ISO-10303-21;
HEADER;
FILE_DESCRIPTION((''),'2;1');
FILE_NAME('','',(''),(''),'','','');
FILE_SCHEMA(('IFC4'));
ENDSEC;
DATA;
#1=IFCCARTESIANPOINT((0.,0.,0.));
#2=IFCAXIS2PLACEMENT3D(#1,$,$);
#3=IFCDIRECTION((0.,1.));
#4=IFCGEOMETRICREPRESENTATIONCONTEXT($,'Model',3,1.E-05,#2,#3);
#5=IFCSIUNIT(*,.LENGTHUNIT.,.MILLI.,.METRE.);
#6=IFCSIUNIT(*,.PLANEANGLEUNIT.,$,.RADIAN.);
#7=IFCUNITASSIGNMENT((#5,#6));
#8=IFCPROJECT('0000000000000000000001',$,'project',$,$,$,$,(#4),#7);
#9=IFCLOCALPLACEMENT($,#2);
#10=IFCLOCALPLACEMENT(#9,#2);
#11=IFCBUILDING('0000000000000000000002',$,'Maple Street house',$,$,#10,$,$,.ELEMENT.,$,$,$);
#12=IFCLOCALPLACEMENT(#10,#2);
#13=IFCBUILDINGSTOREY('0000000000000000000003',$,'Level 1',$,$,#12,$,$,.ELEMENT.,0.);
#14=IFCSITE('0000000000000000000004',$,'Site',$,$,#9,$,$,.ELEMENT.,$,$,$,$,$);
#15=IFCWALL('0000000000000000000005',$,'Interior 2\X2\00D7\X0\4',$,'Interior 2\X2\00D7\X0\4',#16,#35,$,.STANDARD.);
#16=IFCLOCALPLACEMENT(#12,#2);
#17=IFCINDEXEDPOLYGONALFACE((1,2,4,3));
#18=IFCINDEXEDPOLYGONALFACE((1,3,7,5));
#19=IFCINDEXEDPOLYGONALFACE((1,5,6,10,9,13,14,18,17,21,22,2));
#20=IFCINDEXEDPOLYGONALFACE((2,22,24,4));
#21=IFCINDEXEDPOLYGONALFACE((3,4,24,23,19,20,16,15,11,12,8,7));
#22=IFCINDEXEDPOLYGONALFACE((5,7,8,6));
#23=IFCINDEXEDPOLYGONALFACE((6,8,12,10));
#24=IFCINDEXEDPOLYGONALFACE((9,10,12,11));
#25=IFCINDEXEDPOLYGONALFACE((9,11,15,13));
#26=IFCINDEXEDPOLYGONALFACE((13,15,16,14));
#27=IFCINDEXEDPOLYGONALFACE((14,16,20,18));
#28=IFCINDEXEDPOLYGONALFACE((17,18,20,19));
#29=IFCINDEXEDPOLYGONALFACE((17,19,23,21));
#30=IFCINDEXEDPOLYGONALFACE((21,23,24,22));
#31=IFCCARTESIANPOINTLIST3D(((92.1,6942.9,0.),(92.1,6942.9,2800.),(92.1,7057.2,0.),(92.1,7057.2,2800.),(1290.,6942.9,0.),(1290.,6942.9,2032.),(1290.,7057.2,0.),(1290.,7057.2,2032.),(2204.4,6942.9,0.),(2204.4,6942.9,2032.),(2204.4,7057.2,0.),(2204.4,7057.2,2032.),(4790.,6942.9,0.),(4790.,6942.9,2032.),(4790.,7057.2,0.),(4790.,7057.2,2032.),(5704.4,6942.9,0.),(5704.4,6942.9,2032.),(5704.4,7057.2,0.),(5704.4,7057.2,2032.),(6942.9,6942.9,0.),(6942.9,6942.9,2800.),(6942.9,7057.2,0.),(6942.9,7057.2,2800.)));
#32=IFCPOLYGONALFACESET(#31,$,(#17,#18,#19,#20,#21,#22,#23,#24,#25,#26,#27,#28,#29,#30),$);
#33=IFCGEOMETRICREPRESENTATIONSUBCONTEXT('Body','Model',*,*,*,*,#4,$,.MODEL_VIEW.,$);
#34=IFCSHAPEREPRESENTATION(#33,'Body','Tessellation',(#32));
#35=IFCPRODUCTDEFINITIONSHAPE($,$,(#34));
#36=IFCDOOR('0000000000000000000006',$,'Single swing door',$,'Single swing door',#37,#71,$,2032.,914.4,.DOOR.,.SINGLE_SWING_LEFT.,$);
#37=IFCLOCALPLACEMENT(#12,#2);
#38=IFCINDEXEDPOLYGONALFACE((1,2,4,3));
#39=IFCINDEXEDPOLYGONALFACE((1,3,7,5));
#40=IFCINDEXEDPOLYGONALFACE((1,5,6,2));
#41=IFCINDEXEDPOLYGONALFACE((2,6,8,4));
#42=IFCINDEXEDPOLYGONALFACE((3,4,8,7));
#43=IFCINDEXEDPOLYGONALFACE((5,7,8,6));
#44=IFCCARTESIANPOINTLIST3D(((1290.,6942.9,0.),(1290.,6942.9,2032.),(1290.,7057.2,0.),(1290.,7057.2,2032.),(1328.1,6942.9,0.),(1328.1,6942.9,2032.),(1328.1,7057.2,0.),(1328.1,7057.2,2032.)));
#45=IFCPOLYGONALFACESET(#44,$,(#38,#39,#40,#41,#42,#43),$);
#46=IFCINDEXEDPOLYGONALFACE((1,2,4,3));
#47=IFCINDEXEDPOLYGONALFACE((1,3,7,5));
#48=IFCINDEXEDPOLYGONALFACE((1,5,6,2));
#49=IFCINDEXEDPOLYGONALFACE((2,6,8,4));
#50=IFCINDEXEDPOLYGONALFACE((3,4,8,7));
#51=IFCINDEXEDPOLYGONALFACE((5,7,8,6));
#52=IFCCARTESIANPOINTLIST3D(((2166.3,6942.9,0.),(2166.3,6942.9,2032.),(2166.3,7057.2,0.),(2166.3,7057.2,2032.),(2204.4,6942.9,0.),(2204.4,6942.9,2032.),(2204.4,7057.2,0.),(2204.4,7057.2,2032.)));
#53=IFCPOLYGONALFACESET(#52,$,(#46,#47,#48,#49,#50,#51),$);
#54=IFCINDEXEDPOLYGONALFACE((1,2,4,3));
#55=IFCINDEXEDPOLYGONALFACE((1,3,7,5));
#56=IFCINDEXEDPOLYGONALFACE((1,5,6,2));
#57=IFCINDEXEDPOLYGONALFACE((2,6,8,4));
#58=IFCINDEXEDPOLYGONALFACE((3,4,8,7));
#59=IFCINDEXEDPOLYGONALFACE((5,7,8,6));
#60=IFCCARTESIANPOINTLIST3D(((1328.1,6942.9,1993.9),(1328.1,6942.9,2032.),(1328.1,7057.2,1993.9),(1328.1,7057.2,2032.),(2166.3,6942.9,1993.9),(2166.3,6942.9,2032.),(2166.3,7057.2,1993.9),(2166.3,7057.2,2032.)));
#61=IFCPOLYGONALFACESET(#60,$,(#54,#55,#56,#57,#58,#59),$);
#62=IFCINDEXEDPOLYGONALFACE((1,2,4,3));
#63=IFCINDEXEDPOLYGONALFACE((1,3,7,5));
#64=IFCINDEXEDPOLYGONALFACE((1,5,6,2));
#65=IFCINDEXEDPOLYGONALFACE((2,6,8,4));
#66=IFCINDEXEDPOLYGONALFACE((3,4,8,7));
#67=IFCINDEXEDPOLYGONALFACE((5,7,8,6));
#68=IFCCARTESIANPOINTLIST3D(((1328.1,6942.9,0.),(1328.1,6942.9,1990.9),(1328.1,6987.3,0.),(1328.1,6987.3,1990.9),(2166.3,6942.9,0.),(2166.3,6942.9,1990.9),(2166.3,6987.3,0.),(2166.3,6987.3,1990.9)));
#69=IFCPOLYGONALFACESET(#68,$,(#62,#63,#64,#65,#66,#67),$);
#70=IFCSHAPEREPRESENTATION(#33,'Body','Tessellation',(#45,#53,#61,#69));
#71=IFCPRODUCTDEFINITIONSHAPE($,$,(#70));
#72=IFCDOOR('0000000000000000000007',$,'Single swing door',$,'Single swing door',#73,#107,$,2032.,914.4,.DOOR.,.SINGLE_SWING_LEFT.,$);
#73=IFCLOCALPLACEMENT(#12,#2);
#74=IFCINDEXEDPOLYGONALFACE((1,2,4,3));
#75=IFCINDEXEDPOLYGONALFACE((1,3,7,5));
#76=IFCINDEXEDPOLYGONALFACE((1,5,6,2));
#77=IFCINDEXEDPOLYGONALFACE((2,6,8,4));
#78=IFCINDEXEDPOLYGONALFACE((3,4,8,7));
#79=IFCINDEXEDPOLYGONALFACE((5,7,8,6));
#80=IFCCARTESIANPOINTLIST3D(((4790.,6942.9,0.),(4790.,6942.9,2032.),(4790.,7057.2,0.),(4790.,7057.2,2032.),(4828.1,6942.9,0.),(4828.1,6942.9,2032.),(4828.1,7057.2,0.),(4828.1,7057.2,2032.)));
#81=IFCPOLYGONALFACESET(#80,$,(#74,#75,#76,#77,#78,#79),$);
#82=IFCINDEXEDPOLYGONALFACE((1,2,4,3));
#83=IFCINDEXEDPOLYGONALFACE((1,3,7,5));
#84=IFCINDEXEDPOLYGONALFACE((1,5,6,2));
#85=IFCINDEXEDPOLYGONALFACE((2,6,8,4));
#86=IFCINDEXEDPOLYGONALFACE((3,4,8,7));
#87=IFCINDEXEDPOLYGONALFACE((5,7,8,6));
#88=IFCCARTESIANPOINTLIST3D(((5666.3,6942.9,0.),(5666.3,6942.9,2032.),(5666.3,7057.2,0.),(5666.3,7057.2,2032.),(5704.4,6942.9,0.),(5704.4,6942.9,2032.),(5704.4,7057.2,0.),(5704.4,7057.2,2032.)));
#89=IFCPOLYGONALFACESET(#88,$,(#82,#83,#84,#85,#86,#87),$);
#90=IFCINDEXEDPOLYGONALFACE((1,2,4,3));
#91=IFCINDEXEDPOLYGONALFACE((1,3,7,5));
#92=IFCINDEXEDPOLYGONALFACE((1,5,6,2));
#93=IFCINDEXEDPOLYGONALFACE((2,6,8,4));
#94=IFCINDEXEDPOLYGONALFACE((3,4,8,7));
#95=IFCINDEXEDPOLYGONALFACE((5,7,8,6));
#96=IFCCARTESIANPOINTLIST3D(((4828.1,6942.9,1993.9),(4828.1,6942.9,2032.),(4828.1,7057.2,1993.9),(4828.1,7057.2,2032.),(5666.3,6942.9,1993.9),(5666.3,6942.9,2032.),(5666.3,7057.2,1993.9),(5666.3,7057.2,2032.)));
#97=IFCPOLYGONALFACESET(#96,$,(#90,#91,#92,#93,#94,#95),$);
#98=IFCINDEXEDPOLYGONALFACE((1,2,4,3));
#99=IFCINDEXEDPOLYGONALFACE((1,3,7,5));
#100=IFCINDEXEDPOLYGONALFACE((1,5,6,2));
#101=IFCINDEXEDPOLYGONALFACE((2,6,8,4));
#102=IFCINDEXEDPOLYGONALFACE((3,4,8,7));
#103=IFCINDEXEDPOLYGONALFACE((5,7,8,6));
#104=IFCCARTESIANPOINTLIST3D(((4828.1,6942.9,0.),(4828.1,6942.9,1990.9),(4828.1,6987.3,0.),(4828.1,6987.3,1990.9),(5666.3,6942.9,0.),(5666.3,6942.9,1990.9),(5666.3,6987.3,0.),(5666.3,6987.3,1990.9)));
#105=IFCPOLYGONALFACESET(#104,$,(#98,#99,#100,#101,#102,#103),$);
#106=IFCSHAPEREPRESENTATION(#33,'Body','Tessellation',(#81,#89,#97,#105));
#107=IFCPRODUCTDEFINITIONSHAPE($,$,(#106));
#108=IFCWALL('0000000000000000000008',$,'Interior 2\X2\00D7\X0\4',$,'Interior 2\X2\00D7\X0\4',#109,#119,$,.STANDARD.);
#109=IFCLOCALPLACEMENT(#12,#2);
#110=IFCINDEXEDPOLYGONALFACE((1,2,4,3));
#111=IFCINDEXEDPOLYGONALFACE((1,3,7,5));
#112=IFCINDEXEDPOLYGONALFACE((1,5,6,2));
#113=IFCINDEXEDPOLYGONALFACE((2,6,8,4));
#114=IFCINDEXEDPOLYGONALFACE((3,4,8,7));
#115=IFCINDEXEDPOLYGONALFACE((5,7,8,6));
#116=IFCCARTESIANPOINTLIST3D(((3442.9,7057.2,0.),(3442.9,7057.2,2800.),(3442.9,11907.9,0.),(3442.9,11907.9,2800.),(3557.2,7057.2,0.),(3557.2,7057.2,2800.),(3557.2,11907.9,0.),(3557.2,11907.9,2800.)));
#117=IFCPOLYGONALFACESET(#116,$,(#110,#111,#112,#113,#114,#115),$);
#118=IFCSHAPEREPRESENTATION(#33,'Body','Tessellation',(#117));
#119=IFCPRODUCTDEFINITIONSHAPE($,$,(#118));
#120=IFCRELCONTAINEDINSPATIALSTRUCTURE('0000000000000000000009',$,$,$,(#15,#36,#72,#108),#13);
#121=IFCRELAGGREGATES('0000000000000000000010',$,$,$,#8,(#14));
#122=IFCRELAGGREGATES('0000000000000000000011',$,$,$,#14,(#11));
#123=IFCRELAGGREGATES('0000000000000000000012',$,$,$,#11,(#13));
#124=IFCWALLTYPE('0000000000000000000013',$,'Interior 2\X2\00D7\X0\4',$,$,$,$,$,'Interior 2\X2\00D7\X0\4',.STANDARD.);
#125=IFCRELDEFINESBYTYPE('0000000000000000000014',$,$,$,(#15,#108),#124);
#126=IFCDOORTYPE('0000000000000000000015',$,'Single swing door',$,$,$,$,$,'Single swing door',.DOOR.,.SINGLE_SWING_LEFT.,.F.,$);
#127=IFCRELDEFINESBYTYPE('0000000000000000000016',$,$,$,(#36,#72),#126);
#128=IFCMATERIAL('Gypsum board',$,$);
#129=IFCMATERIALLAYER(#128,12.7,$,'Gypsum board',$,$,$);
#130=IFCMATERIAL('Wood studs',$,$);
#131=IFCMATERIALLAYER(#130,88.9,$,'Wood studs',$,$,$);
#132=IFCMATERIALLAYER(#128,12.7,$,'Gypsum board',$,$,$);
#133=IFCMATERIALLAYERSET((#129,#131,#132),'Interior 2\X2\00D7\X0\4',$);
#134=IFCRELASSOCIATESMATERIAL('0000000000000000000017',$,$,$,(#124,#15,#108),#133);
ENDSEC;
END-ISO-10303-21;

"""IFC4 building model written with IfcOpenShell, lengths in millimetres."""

from ifc_helpers import new_model, si_unit, direction, frame, origin, origin_with_axes, place, context, subcontext, project, spatial, polyline, outline, extrude, material, layer, layer_set, layer_usage, type_object, element, fill, save


model = new_model("IFC4")

# Units and contexts
model_context = context("Model", 3, precision=1e-05, world=origin(), true_north=direction((0.0, 1.0)))
body_context = subcontext(model_context, "Body", "Model", "MODEL_VIEW")
ifc_project = project(units=[si_unit("LENGTHUNIT", "METRE", prefix="MILLI"), si_unit("PLANEANGLEUNIT", "RADIAN")], contexts=[model_context])

# Site, building, storey
site_placement = place(None, origin())
site = spatial("IfcSite", under=ifc_project, at=site_placement, Name="Site", CompositionType="ELEMENT")
building_placement = place(site_placement, origin())
building = spatial("IfcBuilding", under=site, at=building_placement, Name="Maple Street house", CompositionType="ELEMENT")
storey_placement = place(building_placement, origin())
storey = spatial("IfcBuildingStorey", under=building, at=storey_placement, Name="Level 1", CompositionType="ELEMENT", Elevation=0.0)

# Shared definitions
ifc_material_1 = material(Name="Wood studs")
ifc_material_2 = material(Name="Gypsum board")

# Wall, openings, doors
ifc_layer_1 = layer(ifc_material_2, 12.7, Name="Gypsum board")
ifc_layer_2 = layer(ifc_material_1, 88.9, Name="Wood studs")
ifc_layer_3 = layer(ifc_material_2, 12.7, Name="Gypsum board")
ifc_layer_set_1 = layer_set([ifc_layer_1, ifc_layer_2, ifc_layer_3], Name="Interior 2×4")
ifc_layer_usage_1 = layer_usage(ifc_layer_set_1, "AXIS2", "NEGATIVE", 57.1)
wall_type_1 = type_object("IfcWallType", Name="Interior 2×4", ElementType="Interior 2×4", PredefinedType="STANDARD", material=ifc_layer_set_1)
wall_1_placement = place(storey_placement, frame((0.0, 7000.0, 0.0), z_axis=(0.0, 0.0, 1.0), x_axis=(1.0, 0.0, 0.0)))
wall_1 = element("IfcWall", 1, at=wall_1_placement, inside=storey, type_object=wall_type_1, material=ifc_layer_usage_1, Name="Interior 2×4", ObjectType="Interior 2×4", PredefinedType="STANDARD", context=body_context, shape_type="SweptSolid", body=[
    extrude(outline(polyline([(92.1, -57.1), (6942.9, -57.1), (6942.9, 57.1), (92.1, 57.1), (92.1, -57.1)])), origin(), (0.0, 0.0, 1.0), 2800.0),
])
opening_1_placement = place(wall_1_placement, frame((1290.0, 0.0, 0.0), z_axis=(0.0, 0.0, 1.0), x_axis=(1.0, 0.0, 0.0)))
opening_1 = element("IfcOpeningElement", 2, at=opening_1_placement, cuts=wall_1, PredefinedType="OPENING", context=body_context, shape_type="SweptSolid", body=[
    extrude(outline(polyline([(0.0, -67.2), (914.4, -67.2), (914.4, 67.2), (0.0, 67.2), (0.0, -67.2)])), origin(), (0.0, 0.0, 1.0), 2032.0),
])
opening_2_placement = place(wall_1_placement, frame((4790.0, 0.0, 0.0), z_axis=(0.0, 0.0, 1.0), x_axis=(1.0, 0.0, 0.0)))
opening_2 = element("IfcOpeningElement", 3, at=opening_2_placement, cuts=wall_1, PredefinedType="OPENING", context=body_context, shape_type="SweptSolid", body=[
    extrude(outline(polyline([(0.0, -67.2), (914.4, -67.2), (914.4, 67.2), (0.0, 67.2), (0.0, -67.2)])), origin(), (0.0, 0.0, 1.0), 2032.0),
])
door_type_1 = type_object("IfcDoorType", Name="Single swing door", ElementType="Single swing door", OperationType="SINGLE_SWING_LEFT", ParameterTakesPrecedence=False, PredefinedType="DOOR")
door_1_placement = place(opening_1_placement, origin_with_axes())
door_1 = element("IfcDoor", 4, at=door_1_placement, inside=storey, type_object=door_type_1, Name="Single swing door", ObjectType="Single swing door", OperationType="SINGLE_SWING_LEFT", OverallHeight=2032.0, OverallWidth=914.4, PredefinedType="DOOR", context=body_context, shape_type="SweptSolid", body=[
    extrude(outline(polyline([(0.0, -57.1), (38.1, -57.1), (38.1, 57.1), (0.0, 57.1), (0.0, -57.1)])), origin(), (0.0, 0.0, 1.0), 2032.0),
    extrude(outline(polyline([(876.3, -57.1), (914.4, -57.1), (914.4, 57.1), (876.3, 57.1), (876.3, -57.1)])), origin(), (0.0, 0.0, 1.0), 2032.0),
    extrude(outline(polyline([(38.1, -57.1), (876.3, -57.1), (876.3, 57.1), (38.1, 57.1), (38.1, -57.1)])), frame((0.0, 0.0, 1993.9)), (0.0, 0.0, 1.0), 38.1),
    extrude(outline(polyline([(38.1, -57.1), (876.3, -57.1), (876.3, -12.7), (38.1, -12.7), (38.1, -57.1)])), origin(), (0.0, 0.0, 1.0), 1990.9),
])
fill(opening_1, door_1)
door_2_placement = place(opening_2_placement, origin_with_axes())
door_2 = element("IfcDoor", 5, at=door_2_placement, inside=storey, type_object=door_type_1, Name="Single swing door", ObjectType="Single swing door", OperationType="SINGLE_SWING_LEFT", OverallHeight=2032.0, OverallWidth=914.4, PredefinedType="DOOR", context=body_context, shape_type="SweptSolid", body=[
    extrude(outline(polyline([(0.0, -57.1), (38.1, -57.1), (38.1, 57.1), (0.0, 57.1), (0.0, -57.1)])), origin(), (0.0, 0.0, 1.0), 2032.0),
    extrude(outline(polyline([(876.3, -57.1), (914.4, -57.1), (914.4, 57.1), (876.3, 57.1), (876.3, -57.1)])), origin(), (0.0, 0.0, 1.0), 2032.0),
    extrude(outline(polyline([(38.1, -57.1), (876.3, -57.1), (876.3, 57.1), (38.1, 57.1), (38.1, -57.1)])), frame((0.0, 0.0, 1993.9)), (0.0, 0.0, 1.0), 38.1),
    extrude(outline(polyline([(38.1, -57.1), (876.3, -57.1), (876.3, -12.7), (38.1, -12.7), (38.1, -57.1)])), origin(), (0.0, 0.0, 1.0), 1990.9),
])
fill(opening_2, door_2)

# Wall
ifc_layer_usage_2 = layer_usage(ifc_layer_set_1, "AXIS2", "NEGATIVE", 57.1)
wall_2_placement = place(storey_placement, frame((3500.0, 7000.0, 0.0), z_axis=(0.0, 0.0, 1.0), x_axis=(0.0, 1.0, 0.0)))
element("IfcWall", 6, at=wall_2_placement, inside=storey, type_object=wall_type_1, material=ifc_layer_usage_2, Name="Interior 2×4", ObjectType="Interior 2×4", PredefinedType="STANDARD", context=body_context, shape_type="SweptSolid", body=[
    extrude(outline(polyline([(57.1, -57.1), (4907.9, -57.1), (4907.9, 57.1), (57.1, 57.1), (57.1, -57.1)])), origin(), (0.0, 0.0, 1.0), 2800.0),
])

save(model, "model.ifc")
